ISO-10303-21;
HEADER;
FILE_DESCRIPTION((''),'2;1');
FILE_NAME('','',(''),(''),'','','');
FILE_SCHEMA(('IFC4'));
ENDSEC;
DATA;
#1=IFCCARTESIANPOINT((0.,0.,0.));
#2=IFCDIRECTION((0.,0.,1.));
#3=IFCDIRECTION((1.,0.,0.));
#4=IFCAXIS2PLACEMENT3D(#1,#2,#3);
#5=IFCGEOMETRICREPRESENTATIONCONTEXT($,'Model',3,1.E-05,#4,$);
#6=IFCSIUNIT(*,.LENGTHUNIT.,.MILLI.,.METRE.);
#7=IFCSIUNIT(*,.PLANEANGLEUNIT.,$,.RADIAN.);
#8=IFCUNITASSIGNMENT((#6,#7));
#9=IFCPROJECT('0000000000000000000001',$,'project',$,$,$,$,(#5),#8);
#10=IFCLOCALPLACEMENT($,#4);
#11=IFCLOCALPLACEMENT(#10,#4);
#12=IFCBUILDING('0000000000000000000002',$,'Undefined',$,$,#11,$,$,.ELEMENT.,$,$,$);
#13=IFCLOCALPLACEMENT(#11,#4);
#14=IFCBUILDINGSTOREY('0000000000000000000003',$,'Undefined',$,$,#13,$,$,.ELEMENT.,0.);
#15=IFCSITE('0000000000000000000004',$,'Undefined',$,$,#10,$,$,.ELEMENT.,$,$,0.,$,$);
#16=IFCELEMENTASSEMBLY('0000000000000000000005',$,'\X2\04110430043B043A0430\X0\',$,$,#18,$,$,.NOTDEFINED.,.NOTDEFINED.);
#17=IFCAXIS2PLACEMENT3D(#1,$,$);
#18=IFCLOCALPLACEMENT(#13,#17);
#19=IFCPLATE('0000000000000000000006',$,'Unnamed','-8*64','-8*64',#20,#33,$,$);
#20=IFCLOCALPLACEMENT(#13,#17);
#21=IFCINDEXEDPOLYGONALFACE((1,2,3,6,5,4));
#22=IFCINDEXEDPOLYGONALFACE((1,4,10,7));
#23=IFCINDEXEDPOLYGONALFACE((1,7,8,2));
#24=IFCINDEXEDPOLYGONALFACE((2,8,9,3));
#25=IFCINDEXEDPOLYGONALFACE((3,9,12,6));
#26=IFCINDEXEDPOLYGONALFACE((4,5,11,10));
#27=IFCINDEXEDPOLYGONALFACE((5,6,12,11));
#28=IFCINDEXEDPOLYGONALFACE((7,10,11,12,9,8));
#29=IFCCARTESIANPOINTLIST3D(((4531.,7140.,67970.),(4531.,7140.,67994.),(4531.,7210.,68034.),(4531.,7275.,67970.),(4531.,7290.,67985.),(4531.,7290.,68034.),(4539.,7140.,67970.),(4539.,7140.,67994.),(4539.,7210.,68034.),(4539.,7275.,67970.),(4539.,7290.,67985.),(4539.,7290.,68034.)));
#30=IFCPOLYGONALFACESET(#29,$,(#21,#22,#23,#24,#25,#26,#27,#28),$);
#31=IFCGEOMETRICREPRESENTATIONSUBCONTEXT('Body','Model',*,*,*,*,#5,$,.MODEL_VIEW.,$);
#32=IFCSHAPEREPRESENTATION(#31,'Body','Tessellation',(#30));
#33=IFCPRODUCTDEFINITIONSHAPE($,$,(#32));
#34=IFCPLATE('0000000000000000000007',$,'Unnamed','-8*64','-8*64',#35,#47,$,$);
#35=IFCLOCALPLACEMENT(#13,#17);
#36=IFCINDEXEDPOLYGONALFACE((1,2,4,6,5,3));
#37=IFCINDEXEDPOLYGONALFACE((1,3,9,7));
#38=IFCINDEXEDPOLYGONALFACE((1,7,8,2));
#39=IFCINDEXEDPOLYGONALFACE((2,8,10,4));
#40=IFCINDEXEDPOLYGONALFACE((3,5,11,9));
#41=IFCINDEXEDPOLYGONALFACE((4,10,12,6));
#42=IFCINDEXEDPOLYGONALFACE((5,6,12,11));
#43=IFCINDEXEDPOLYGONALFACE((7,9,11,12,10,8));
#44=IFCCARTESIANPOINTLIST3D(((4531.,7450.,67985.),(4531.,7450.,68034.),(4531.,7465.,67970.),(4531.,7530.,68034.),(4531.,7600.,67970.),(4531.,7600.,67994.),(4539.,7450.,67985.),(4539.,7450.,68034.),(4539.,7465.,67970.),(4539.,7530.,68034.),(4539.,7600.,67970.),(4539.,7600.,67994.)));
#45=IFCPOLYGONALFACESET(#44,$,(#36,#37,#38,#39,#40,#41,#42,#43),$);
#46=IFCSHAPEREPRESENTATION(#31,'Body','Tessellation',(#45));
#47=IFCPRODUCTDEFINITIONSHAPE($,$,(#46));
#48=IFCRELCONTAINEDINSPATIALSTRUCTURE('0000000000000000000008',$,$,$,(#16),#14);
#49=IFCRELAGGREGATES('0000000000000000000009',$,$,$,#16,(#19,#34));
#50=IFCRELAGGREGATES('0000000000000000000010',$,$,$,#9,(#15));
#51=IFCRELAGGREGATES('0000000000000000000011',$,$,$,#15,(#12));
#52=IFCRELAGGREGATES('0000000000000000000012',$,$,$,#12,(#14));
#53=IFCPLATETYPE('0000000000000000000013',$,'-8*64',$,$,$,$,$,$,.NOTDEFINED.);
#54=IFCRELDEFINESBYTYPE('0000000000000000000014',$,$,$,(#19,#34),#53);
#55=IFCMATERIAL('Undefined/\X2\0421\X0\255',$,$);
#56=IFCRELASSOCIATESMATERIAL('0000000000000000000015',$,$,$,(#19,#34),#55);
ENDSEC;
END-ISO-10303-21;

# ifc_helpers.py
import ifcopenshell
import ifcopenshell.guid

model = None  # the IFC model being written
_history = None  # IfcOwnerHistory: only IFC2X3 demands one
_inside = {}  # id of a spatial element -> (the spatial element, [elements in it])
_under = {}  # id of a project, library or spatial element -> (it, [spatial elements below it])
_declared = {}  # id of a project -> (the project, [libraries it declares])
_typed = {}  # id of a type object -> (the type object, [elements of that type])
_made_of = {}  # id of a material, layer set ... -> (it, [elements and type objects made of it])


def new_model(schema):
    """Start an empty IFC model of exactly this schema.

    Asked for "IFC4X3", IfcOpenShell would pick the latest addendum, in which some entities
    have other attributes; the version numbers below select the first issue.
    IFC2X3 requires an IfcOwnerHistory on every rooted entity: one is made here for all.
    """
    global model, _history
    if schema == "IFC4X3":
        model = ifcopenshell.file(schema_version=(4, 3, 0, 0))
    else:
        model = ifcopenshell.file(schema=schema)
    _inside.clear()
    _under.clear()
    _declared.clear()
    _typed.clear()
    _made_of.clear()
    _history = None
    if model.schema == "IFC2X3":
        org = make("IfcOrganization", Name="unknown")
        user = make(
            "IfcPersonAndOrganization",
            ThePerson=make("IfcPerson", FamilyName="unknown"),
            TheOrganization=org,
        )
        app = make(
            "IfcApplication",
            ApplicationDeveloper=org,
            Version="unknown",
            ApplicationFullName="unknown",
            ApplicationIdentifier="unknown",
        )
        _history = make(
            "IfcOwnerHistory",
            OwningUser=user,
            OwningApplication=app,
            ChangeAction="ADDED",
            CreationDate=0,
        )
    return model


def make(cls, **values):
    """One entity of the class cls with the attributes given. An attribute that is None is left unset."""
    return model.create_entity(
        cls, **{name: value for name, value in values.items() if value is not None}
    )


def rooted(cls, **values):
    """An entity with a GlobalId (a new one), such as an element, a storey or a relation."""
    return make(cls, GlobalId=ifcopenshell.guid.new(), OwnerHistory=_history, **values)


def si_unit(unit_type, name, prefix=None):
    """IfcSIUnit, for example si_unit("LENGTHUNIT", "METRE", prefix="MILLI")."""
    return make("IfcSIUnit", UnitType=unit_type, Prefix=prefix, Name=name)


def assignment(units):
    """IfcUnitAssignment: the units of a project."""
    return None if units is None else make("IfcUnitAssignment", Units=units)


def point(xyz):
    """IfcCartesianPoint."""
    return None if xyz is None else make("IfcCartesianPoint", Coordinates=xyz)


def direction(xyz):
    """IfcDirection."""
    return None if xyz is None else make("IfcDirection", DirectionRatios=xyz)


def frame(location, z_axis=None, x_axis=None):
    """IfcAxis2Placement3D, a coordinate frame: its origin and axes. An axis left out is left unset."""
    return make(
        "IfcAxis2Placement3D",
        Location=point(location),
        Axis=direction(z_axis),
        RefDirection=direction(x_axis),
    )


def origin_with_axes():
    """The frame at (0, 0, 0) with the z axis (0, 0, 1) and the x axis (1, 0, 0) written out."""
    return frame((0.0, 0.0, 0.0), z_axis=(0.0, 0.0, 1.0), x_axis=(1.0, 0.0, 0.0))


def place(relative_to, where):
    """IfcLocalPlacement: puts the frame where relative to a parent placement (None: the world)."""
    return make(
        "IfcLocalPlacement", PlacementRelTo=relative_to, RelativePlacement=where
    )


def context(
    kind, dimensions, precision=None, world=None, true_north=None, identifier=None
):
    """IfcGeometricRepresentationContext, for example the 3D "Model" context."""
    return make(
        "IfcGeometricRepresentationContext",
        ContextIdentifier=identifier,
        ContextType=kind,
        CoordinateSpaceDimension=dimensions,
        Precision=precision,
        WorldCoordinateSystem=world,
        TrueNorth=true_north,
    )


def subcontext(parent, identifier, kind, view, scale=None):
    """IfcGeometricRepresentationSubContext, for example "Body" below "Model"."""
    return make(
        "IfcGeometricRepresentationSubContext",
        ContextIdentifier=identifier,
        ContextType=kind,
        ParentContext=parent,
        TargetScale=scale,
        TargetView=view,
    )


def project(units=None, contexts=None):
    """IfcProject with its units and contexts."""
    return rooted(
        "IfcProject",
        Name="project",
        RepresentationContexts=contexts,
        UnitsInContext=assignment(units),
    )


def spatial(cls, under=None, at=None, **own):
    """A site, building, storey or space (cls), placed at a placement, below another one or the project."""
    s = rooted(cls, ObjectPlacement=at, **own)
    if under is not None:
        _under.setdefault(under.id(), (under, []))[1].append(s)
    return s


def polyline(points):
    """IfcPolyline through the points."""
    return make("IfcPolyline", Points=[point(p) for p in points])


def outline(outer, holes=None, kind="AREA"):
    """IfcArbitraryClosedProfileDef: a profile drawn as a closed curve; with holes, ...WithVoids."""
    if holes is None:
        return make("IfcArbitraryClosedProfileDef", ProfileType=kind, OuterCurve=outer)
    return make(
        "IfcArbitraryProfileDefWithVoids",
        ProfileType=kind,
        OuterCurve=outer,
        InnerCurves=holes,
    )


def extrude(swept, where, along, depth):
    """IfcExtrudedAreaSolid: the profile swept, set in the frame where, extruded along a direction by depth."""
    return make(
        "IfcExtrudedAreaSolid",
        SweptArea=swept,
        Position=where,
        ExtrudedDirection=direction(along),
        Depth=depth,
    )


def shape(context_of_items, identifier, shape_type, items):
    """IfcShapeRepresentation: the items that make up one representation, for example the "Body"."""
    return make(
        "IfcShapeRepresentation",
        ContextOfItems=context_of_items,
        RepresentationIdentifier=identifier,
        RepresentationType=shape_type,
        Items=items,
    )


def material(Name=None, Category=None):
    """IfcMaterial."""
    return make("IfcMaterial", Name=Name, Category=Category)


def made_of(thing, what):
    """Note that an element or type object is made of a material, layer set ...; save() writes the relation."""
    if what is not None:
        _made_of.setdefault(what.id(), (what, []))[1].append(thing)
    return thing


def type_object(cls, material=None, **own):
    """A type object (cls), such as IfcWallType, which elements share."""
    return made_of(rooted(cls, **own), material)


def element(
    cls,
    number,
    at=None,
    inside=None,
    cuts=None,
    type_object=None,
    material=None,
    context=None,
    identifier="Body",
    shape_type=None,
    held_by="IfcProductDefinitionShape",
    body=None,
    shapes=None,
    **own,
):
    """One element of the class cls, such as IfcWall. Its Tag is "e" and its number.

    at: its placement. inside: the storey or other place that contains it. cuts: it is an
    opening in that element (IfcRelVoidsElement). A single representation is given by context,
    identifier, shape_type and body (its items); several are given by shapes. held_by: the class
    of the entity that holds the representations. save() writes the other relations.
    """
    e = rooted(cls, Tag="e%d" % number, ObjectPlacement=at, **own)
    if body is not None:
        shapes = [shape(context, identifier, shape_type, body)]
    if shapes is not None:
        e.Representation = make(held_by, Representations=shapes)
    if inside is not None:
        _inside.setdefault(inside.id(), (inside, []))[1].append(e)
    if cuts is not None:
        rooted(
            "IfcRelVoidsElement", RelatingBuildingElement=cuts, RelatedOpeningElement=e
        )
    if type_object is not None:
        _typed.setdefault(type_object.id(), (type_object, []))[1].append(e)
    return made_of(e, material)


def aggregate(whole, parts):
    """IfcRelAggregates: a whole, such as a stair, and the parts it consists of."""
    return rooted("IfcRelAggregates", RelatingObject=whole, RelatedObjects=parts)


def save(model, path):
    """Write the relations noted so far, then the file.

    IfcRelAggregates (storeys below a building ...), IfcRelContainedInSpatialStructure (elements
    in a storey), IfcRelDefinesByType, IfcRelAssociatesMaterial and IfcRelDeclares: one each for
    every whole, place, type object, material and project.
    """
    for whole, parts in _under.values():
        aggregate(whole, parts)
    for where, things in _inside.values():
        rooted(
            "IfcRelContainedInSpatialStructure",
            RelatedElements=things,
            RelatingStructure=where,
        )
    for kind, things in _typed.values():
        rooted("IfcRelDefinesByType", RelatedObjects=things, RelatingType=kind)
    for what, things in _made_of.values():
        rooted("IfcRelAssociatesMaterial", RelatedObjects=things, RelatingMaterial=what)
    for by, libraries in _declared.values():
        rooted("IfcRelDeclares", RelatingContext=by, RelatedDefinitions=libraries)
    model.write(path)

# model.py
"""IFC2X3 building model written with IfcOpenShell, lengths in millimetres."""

from ifc_helpers import new_model, si_unit, frame, origin_with_axes, place, context, subcontext, project, spatial, polyline, outline, extrude, material, type_object, element, aggregate, save


model = new_model("IFC2X3")

# Units and contexts
model_context = context("Model", 3, precision=1e-05, world=origin_with_axes())
body_context = subcontext(model_context, "Body", "Model", "MODEL_VIEW")
ifc_project = project(units=[si_unit("LENGTHUNIT", "METRE", prefix="MILLI"), si_unit("PLANEANGLEUNIT", "RADIAN")], contexts=[model_context])

# Site, building, storey
site_placement = place(None, origin_with_axes())
site = spatial("IfcSite", under=ifc_project, at=site_placement, Name="Undefined", CompositionType="ELEMENT", RefElevation=0.0)
building_placement = place(site_placement, origin_with_axes())
building = spatial("IfcBuilding", under=site, at=building_placement, Name="Undefined", CompositionType="ELEMENT")
storey_placement = place(building_placement, origin_with_axes())
storey = spatial("IfcBuildingStorey", under=building, at=storey_placement, Name="Undefined", CompositionType="ELEMENT", Elevation=0.0)

# Shared definitions
ifc_material_1 = material(Name="Undefined/С255")

# Element assembly
assembly_1_placement = place(storey_placement, origin_with_axes())
assembly_1 = element("IfcElementAssembly", 1, at=assembly_1_placement, inside=storey, Name="Балка", AssemblyPlace="NOTDEFINED", PredefinedType="NOTDEFINED")

# Plates
plate_type = type_object("IfcPlateType", Name="-8*64", PredefinedType="NOTDEFINED")
plate_1_placement = place(assembly_1_placement, frame((4535.0, 7140.0, 67970.0), z_axis=(1.0, 0.0, 0.0), x_axis=(0.0, 1.0, 0.0)))
plate_1 = element("IfcPlate", 2, at=plate_1_placement, type_object=plate_type, material=ifc_material_1, Name="Unnamed", Description="-8*64", ObjectType="-8*64", context=body_context, shape_type="SweptSolid", body=[
    extrude(outline(polyline([(0.0, 0.0), (135.0, 0.0), (150.0, 15.0), (150.0, 64.0), (70.0, 64.0), (0.0, 24.0), (0.0, 0.0)])), frame((0.0, 0.0, -4.0), z_axis=(0.0, 0.0, 1.0), x_axis=(1.0, 0.0, 0.0)), (0.0, 0.0, 1.0), 8.0),
])
plate_2_placement = place(assembly_1_placement, frame((4535.0, 7600.0, 67970.0), z_axis=(-1.0, 0.0, 0.0), x_axis=(0.0, -1.0, 0.0)))
plate_2 = element("IfcPlate", 3, at=plate_2_placement, type_object=plate_type, material=ifc_material_1, Name="Unnamed", Description="-8*64", ObjectType="-8*64", context=body_context, shape_type="SweptSolid", body=[
    extrude(outline(polyline([(0.0, 0.0), (135.0, 0.0), (150.0, 15.0), (150.0, 64.0), (70.0, 64.0), (0.0, 24.0), (0.0, 0.0)])), frame((0.0, 0.0, -4.0), z_axis=(0.0, 0.0, 1.0), x_axis=(1.0, 0.0, 0.0)), (0.0, 0.0, 1.0), 8.0),
])

aggregate(assembly_1, [plate_1, plate_2])

save(model, "model.ifc")
